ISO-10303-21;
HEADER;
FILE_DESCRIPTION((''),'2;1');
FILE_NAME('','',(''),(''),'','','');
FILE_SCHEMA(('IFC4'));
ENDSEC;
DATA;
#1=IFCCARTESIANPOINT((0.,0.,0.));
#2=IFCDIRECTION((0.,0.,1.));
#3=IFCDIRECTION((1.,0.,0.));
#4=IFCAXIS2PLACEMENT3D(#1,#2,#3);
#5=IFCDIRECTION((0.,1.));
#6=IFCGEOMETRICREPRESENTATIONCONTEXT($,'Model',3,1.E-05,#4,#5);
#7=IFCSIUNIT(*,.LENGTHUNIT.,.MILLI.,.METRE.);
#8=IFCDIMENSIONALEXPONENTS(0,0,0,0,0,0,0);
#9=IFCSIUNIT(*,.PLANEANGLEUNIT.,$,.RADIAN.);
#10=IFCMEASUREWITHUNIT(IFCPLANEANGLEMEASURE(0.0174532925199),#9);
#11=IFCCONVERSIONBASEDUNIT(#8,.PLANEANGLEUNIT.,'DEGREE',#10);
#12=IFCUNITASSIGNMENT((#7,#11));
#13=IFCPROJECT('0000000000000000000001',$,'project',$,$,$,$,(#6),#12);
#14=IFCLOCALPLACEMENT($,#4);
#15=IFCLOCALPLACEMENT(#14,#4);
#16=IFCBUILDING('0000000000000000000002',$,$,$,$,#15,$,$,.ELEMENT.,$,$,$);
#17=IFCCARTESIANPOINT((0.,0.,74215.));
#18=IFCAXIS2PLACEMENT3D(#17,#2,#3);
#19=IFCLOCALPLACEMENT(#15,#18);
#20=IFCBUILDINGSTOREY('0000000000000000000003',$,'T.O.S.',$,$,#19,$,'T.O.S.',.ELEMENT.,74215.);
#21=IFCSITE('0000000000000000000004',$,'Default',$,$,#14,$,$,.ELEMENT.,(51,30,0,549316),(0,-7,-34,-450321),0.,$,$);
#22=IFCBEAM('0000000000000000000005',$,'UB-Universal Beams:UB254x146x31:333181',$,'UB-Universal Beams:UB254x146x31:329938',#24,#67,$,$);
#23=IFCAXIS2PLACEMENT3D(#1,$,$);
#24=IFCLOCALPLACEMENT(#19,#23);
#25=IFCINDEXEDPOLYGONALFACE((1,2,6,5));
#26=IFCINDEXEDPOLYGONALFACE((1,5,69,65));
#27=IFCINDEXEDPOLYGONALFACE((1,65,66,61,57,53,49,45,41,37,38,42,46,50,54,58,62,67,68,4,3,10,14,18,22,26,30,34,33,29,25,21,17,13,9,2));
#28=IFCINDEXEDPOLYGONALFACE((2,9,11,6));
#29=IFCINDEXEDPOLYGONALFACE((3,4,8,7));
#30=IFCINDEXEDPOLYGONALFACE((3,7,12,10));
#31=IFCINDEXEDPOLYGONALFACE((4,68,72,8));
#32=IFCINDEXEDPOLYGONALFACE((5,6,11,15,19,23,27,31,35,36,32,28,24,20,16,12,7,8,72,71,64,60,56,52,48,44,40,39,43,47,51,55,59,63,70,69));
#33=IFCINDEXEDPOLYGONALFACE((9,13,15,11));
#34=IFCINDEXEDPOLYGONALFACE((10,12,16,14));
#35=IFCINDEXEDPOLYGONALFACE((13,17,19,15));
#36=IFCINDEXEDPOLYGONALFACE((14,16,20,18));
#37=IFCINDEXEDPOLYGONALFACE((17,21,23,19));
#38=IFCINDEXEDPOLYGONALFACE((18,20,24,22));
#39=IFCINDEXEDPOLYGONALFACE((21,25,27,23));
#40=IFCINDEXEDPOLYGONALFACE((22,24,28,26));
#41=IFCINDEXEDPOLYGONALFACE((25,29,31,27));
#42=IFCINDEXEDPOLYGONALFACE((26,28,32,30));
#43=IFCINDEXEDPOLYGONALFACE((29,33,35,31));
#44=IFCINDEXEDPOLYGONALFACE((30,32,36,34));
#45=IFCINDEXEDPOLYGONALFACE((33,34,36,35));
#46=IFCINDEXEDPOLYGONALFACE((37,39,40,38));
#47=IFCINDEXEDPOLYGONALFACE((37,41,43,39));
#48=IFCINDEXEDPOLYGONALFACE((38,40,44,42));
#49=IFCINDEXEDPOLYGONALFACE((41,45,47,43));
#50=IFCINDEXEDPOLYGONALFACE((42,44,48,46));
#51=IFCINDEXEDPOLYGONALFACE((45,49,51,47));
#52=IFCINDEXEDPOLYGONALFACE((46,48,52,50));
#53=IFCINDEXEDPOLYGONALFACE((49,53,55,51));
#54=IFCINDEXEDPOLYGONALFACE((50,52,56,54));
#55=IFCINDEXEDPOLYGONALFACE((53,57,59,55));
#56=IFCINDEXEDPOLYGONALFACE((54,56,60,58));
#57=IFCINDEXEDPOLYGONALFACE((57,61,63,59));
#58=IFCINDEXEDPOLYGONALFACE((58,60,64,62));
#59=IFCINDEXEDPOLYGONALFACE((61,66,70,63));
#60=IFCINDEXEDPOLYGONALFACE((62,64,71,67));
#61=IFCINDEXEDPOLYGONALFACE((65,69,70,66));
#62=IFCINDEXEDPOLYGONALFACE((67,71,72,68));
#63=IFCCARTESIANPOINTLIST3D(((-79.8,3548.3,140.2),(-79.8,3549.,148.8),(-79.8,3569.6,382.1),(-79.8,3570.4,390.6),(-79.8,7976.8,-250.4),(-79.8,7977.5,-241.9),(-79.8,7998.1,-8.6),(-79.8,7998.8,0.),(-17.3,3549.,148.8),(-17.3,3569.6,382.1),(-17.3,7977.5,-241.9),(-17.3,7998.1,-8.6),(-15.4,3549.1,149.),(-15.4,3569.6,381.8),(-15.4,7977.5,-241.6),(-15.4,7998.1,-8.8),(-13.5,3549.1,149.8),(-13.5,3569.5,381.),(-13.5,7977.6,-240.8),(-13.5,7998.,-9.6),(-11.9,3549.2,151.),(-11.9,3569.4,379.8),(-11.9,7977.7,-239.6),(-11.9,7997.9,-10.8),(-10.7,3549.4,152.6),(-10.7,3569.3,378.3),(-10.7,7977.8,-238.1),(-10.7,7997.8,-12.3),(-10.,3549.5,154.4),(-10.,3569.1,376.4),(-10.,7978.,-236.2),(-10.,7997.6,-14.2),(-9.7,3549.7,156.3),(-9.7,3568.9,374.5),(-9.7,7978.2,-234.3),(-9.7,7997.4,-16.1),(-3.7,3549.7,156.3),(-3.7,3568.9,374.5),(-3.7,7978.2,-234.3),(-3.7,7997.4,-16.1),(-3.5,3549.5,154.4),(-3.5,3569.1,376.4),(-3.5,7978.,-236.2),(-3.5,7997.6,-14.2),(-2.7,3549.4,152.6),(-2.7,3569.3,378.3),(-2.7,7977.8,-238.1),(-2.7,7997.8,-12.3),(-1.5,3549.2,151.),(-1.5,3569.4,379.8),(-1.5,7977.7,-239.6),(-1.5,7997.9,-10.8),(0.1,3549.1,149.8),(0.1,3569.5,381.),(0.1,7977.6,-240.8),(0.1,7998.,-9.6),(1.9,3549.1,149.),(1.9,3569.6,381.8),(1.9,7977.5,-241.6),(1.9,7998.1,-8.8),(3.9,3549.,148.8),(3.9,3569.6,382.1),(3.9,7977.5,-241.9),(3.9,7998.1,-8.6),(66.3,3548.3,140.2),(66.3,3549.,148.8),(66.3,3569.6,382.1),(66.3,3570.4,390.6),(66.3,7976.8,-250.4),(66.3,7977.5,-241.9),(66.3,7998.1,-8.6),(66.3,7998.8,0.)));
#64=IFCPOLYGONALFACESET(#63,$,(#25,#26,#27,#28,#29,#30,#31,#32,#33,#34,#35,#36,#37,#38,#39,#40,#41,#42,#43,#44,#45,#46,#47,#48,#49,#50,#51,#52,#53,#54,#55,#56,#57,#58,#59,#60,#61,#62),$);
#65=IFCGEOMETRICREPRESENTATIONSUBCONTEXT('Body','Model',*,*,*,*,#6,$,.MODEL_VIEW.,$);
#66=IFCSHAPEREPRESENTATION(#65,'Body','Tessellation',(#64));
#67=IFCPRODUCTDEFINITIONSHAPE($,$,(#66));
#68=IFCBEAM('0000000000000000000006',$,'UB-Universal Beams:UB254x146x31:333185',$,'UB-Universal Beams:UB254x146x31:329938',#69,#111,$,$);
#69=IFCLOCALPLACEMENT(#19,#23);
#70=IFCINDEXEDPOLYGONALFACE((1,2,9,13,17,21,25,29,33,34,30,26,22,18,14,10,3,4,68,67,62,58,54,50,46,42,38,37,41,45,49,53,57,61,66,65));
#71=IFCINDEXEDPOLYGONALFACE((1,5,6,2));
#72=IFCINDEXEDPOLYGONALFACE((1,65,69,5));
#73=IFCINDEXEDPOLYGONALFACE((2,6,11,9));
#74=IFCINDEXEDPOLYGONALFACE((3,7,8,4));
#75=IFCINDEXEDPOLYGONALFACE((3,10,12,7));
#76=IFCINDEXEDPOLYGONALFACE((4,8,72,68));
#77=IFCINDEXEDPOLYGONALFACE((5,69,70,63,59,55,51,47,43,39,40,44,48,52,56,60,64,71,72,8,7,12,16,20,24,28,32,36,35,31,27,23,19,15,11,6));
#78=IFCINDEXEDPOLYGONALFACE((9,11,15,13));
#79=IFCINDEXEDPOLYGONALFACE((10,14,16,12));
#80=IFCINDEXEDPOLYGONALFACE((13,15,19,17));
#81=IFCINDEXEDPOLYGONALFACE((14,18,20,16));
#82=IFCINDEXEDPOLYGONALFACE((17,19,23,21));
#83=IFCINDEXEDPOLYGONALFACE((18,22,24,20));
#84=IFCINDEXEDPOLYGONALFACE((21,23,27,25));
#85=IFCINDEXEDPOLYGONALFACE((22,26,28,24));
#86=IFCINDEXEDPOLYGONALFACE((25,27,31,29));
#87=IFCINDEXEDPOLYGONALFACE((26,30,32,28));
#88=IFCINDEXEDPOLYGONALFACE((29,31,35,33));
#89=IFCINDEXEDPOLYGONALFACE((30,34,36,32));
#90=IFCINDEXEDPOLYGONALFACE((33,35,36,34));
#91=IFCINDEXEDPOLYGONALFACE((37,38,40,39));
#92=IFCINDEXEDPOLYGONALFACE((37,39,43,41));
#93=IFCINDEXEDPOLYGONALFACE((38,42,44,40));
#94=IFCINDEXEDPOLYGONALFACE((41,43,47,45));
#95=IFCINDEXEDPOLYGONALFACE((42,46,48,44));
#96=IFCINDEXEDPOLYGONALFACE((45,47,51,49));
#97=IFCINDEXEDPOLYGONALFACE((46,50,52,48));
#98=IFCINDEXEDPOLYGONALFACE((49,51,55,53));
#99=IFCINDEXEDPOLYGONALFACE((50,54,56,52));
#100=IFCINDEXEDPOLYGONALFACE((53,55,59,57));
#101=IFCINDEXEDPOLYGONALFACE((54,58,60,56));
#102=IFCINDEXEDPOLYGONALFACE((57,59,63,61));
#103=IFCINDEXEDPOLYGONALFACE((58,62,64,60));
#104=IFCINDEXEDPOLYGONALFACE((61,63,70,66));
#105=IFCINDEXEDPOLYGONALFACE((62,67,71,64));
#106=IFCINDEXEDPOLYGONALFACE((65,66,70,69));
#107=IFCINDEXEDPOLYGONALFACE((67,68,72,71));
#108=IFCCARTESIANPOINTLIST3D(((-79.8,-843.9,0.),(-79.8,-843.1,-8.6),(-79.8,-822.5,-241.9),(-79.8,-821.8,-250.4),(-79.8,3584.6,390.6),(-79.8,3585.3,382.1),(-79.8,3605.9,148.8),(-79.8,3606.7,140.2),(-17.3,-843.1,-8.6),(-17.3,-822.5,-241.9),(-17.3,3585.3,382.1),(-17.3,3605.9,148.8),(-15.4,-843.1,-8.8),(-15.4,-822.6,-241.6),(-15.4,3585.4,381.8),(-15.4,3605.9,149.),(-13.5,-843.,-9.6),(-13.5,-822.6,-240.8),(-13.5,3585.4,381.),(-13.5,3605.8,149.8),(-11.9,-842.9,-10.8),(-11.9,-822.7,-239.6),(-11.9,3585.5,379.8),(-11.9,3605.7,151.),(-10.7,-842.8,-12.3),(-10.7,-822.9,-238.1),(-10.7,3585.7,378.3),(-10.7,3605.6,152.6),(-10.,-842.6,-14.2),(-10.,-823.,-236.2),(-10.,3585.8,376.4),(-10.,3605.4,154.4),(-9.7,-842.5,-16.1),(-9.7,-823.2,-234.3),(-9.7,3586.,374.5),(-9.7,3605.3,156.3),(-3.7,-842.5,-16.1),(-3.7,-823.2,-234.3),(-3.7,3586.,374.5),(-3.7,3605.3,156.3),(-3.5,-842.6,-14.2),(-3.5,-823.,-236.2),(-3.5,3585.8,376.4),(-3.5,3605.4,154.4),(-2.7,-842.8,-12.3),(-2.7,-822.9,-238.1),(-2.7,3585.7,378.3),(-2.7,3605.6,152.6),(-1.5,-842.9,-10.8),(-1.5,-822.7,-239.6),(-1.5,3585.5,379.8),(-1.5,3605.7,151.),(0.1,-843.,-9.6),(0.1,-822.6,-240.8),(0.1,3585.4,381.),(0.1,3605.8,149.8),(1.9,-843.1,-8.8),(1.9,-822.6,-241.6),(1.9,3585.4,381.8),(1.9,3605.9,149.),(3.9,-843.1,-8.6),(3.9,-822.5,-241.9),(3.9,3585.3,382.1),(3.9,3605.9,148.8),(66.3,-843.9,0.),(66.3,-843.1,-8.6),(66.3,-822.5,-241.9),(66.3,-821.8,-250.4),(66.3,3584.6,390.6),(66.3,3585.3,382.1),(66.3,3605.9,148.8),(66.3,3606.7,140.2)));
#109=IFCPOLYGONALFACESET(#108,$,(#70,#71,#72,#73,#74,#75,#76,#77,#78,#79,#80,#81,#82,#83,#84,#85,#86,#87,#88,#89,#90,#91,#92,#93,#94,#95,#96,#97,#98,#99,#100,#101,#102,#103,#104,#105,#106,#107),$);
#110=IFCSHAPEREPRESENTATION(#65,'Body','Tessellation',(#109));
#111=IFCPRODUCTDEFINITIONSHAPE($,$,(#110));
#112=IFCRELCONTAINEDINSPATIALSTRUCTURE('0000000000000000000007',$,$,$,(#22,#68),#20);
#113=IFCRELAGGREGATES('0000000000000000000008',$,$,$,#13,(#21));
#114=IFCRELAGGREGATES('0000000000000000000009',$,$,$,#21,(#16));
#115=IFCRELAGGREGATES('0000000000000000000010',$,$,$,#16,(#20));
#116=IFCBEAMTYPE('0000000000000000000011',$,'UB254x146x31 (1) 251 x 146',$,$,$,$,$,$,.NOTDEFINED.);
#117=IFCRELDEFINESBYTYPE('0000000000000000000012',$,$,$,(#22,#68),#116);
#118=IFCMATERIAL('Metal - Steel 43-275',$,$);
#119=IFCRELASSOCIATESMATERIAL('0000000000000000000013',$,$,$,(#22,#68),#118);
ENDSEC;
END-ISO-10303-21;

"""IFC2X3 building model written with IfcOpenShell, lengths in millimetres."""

from ifc_helpers import new_model, entity, si_unit, converted_unit, point, direction, frame, frame_2d, origin_with_axes, place, context, subcontext, project, spatial, polyline, circle_curve, parameter, trimmed, segment, composite_curve, outline, extrude, clip, halfspace, material, type_object, element, save


model = new_model("IFC2X3")

# Units and contexts
model_context = context("Model", 3, precision=1e-05, world=origin_with_axes(), true_north=direction((0.0, 1.0)))
body_context = subcontext(model_context, "Body", "Model", "MODEL_VIEW")
ifc_project = project(units=[si_unit("LENGTHUNIT", "METRE", prefix="MILLI"), converted_unit("PLANEANGLEUNIT", "DEGREE", entity("IfcPlaneAngleMeasure", 0.0174532925199), si_unit("PLANEANGLEUNIT", "RADIAN"), dimensions=[0, 0, 0, 0, 0, 0, 0])], contexts=[model_context])

# Site, building, storey
site_placement = place(None, origin_with_axes())
site = spatial("IfcSite", under=ifc_project, at=site_placement, Name="Default", CompositionType="ELEMENT", RefLatitude=(51, 30, 0, 549316), RefLongitude=(0, -7, -34, -450321), RefElevation=0.0)
building_placement = place(site_placement, origin_with_axes())
building = spatial("IfcBuilding", under=site, at=building_placement, CompositionType="ELEMENT")
storey_placement = place(building_placement, frame((0.0, 0.0, 74215.0), z_axis=(0.0, 0.0, 1.0), x_axis=(1.0, 0.0, 0.0)))
storey = spatial("IfcBuildingStorey", under=building, at=storey_placement, Name="T.O.S.", LongName="T.O.S.", CompositionType="ELEMENT", Elevation=74215.0)

# Beams
ifc_material = material(Name="Metal - Steel 43-275")
beam_type_1 = type_object("IfcBeamType", Name="UB254x146x31 (1) 251 x 146", PredefinedType="NOTDEFINED")
beam_1_placement = place(storey_placement, frame((-6.7, 3541.2, 267.0), z_axis=(0.0, 0.0, 1.0), x_axis=(1.0, 0.0, 0.0)))
element("IfcBeam", 1, at=beam_1_placement, inside=storey, type_object=beam_type_1, material=ifc_material, Name="UB-Universal Beams:UB254x146x31:333181", ObjectType="UB-Universal Beams:UB254x146x31:329938", context=body_context, shape_type="Clipping", body=[
    clip(clip(clip(clip(extrude(outline(composite_curve([segment(polyline([(125.7, 73.0), (117.1, 73.0), (117.1, 10.6)]), True, "CONTINUOUS"), segment(trimmed(circle_curve(frame_2d((109.5, 10.6), x_axis=(0.0, -1.0)), 7.6), [point((117.1, 10.6)), parameter(90.0)], [point((109.5, 3.0)), parameter(0.0)], False, "CARTESIAN"), True, "CONTINUOUS"), segment(polyline([(109.5, 3.0), (-109.5, 3.0)]), True, "CONTINUOUS"), segment(trimmed(circle_curve(frame_2d((-109.5, 10.6), x_axis=(-1.0, 0.0)), 7.6), [point((-109.5, 3.0)), parameter(90.0)], [point((-117.1, 10.6)), parameter(0.0)], False, "CARTESIAN"), True, "CONTINUOUS"), segment(polyline([(-117.1, 10.6), (-117.1, 73.0), (-125.7, 73.0), (-125.7, -73.0), (-117.1, -73.0), (-117.1, -10.6)]), True, "CONTINUOUS"), segment(trimmed(circle_curve(frame_2d((-109.5, -10.6), x_axis=(0.0, 1.0)), 7.6), [point((-117.1, -10.6)), parameter(90.0)], [point((-109.5, -3.0)), parameter(0.0)], False, "CARTESIAN"), True, "CONTINUOUS"), segment(polyline([(-109.5, -3.0), (109.5, -3.0)]), True, "CONTINUOUS"), segment(trimmed(circle_curve(frame_2d((109.5, -10.6), x_axis=(1.0, 0.0)), 7.6), [point((109.5, -3.0)), parameter(90.0)], [point((117.1, -10.6)), parameter(0.0)], False, "CARTESIAN"), True, "CONTINUOUS"), segment(polyline([(117.1, -10.6), (117.1, -73.0), (125.7, -73.0), (125.7, 73.0)]), True, "CONTINUOUS")], self_intersect=False)), frame((0.0, 4482.9, -395.4), z_axis=(0.0, -0.996132, 0.087866), x_axis=(0.0, -0.087866, -0.996132)), (0.0, 0.0, 1.0), 4518.6), halfspace(frame((0.0, 4446.6, -392.2), z_axis=(0.0, -0.996132, 0.087866), x_axis=(0.0, -0.087866, -0.996132)), True)), halfspace(frame((0.0, 18.2, -1.6), z_axis=(0.0, 0.996132, -0.087866), x_axis=(0.0, 0.087866, 0.996132)), True)), halfspace(frame((0.0, 4464.8, 0.0), z_axis=(0.0, -1.0, 0.0), x_axis=(0.0, 0.0, -1.0)), True)), halfspace(frame((0.0, 0.0, 0.0), z_axis=(0.0, 1.0, 0.0), x_axis=(0.0, 0.0, 1.0)), True)),
])
beam_2_placement = place(storey_placement, frame((-6.7, 3613.8, 267.0), z_axis=(0.0, 0.0, 1.0), x_axis=(-1.0, 0.0, 0.0)))
element("IfcBeam", 2, at=beam_2_placement, inside=storey, type_object=beam_type_1, material=ifc_material, Name="UB-Universal Beams:UB254x146x31:333185", ObjectType="UB-Universal Beams:UB254x146x31:329938", context=body_context, shape_type="Clipping", body=[
    clip(clip(clip(clip(extrude(outline(composite_curve([segment(polyline([(125.7, 73.0), (117.1, 73.0), (117.1, 10.6)]), True, "CONTINUOUS"), segment(trimmed(circle_curve(frame_2d((109.5, 10.6), x_axis=(0.0, -1.0)), 7.6), [point((117.1, 10.6)), parameter(90.0)], [point((109.5, 3.0)), parameter(0.0)], False, "CARTESIAN"), True, "CONTINUOUS"), segment(polyline([(109.5, 3.0), (-109.5, 3.0)]), True, "CONTINUOUS"), segment(trimmed(circle_curve(frame_2d((-109.5, 10.6), x_axis=(-1.0, 0.0)), 7.6), [point((-109.5, 3.0)), parameter(90.0)], [point((-117.1, 10.6)), parameter(0.0)], False, "CARTESIAN"), True, "CONTINUOUS"), segment(polyline([(-117.1, 10.6), (-117.1, 73.0), (-125.7, 73.0), (-125.7, -73.0), (-117.1, -73.0), (-117.1, -10.6)]), True, "CONTINUOUS"), segment(trimmed(circle_curve(frame_2d((-109.5, -10.6), x_axis=(0.0, 1.0)), 7.6), [point((-117.1, -10.6)), parameter(90.0)], [point((-109.5, -3.0)), parameter(0.0)], False, "CARTESIAN"), True, "CONTINUOUS"), segment(polyline([(-109.5, -3.0), (109.5, -3.0)]), True, "CONTINUOUS"), segment(trimmed(circle_curve(frame_2d((109.5, -10.6), x_axis=(1.0, 0.0)), 7.6), [point((109.5, -3.0)), parameter(90.0)], [point((117.1, -10.6)), parameter(0.0)], False, "CARTESIAN"), True, "CONTINUOUS"), segment(polyline([(117.1, -10.6), (117.1, -73.0), (125.7, -73.0), (125.7, 73.0)]), True, "CONTINUOUS")], self_intersect=False)), frame((0.0, 4482.9, -395.4), z_axis=(0.0, -0.996132, 0.087866), x_axis=(0.0, -0.087866, -0.996132)), (0.0, 0.0, 1.0), 4518.6), halfspace(frame((0.0, 4446.6, -392.2), z_axis=(0.0, -0.996132, 0.087866), x_axis=(0.0, -0.087866, -0.996132)), True)), halfspace(frame((0.0, 18.2, -1.6), z_axis=(0.0, 0.996132, -0.087866), x_axis=(0.0, 0.087866, 0.996132)), True)), halfspace(frame((0.0, 4464.8, 0.0), z_axis=(0.0, -1.0, 0.0), x_axis=(0.0, 0.0, -1.0)), True)), halfspace(frame((0.0, 0.0, 0.0), z_axis=(0.0, 1.0, 0.0), x_axis=(0.0, 0.0, 1.0)), True)),
])

save(model, "model.ifc")
